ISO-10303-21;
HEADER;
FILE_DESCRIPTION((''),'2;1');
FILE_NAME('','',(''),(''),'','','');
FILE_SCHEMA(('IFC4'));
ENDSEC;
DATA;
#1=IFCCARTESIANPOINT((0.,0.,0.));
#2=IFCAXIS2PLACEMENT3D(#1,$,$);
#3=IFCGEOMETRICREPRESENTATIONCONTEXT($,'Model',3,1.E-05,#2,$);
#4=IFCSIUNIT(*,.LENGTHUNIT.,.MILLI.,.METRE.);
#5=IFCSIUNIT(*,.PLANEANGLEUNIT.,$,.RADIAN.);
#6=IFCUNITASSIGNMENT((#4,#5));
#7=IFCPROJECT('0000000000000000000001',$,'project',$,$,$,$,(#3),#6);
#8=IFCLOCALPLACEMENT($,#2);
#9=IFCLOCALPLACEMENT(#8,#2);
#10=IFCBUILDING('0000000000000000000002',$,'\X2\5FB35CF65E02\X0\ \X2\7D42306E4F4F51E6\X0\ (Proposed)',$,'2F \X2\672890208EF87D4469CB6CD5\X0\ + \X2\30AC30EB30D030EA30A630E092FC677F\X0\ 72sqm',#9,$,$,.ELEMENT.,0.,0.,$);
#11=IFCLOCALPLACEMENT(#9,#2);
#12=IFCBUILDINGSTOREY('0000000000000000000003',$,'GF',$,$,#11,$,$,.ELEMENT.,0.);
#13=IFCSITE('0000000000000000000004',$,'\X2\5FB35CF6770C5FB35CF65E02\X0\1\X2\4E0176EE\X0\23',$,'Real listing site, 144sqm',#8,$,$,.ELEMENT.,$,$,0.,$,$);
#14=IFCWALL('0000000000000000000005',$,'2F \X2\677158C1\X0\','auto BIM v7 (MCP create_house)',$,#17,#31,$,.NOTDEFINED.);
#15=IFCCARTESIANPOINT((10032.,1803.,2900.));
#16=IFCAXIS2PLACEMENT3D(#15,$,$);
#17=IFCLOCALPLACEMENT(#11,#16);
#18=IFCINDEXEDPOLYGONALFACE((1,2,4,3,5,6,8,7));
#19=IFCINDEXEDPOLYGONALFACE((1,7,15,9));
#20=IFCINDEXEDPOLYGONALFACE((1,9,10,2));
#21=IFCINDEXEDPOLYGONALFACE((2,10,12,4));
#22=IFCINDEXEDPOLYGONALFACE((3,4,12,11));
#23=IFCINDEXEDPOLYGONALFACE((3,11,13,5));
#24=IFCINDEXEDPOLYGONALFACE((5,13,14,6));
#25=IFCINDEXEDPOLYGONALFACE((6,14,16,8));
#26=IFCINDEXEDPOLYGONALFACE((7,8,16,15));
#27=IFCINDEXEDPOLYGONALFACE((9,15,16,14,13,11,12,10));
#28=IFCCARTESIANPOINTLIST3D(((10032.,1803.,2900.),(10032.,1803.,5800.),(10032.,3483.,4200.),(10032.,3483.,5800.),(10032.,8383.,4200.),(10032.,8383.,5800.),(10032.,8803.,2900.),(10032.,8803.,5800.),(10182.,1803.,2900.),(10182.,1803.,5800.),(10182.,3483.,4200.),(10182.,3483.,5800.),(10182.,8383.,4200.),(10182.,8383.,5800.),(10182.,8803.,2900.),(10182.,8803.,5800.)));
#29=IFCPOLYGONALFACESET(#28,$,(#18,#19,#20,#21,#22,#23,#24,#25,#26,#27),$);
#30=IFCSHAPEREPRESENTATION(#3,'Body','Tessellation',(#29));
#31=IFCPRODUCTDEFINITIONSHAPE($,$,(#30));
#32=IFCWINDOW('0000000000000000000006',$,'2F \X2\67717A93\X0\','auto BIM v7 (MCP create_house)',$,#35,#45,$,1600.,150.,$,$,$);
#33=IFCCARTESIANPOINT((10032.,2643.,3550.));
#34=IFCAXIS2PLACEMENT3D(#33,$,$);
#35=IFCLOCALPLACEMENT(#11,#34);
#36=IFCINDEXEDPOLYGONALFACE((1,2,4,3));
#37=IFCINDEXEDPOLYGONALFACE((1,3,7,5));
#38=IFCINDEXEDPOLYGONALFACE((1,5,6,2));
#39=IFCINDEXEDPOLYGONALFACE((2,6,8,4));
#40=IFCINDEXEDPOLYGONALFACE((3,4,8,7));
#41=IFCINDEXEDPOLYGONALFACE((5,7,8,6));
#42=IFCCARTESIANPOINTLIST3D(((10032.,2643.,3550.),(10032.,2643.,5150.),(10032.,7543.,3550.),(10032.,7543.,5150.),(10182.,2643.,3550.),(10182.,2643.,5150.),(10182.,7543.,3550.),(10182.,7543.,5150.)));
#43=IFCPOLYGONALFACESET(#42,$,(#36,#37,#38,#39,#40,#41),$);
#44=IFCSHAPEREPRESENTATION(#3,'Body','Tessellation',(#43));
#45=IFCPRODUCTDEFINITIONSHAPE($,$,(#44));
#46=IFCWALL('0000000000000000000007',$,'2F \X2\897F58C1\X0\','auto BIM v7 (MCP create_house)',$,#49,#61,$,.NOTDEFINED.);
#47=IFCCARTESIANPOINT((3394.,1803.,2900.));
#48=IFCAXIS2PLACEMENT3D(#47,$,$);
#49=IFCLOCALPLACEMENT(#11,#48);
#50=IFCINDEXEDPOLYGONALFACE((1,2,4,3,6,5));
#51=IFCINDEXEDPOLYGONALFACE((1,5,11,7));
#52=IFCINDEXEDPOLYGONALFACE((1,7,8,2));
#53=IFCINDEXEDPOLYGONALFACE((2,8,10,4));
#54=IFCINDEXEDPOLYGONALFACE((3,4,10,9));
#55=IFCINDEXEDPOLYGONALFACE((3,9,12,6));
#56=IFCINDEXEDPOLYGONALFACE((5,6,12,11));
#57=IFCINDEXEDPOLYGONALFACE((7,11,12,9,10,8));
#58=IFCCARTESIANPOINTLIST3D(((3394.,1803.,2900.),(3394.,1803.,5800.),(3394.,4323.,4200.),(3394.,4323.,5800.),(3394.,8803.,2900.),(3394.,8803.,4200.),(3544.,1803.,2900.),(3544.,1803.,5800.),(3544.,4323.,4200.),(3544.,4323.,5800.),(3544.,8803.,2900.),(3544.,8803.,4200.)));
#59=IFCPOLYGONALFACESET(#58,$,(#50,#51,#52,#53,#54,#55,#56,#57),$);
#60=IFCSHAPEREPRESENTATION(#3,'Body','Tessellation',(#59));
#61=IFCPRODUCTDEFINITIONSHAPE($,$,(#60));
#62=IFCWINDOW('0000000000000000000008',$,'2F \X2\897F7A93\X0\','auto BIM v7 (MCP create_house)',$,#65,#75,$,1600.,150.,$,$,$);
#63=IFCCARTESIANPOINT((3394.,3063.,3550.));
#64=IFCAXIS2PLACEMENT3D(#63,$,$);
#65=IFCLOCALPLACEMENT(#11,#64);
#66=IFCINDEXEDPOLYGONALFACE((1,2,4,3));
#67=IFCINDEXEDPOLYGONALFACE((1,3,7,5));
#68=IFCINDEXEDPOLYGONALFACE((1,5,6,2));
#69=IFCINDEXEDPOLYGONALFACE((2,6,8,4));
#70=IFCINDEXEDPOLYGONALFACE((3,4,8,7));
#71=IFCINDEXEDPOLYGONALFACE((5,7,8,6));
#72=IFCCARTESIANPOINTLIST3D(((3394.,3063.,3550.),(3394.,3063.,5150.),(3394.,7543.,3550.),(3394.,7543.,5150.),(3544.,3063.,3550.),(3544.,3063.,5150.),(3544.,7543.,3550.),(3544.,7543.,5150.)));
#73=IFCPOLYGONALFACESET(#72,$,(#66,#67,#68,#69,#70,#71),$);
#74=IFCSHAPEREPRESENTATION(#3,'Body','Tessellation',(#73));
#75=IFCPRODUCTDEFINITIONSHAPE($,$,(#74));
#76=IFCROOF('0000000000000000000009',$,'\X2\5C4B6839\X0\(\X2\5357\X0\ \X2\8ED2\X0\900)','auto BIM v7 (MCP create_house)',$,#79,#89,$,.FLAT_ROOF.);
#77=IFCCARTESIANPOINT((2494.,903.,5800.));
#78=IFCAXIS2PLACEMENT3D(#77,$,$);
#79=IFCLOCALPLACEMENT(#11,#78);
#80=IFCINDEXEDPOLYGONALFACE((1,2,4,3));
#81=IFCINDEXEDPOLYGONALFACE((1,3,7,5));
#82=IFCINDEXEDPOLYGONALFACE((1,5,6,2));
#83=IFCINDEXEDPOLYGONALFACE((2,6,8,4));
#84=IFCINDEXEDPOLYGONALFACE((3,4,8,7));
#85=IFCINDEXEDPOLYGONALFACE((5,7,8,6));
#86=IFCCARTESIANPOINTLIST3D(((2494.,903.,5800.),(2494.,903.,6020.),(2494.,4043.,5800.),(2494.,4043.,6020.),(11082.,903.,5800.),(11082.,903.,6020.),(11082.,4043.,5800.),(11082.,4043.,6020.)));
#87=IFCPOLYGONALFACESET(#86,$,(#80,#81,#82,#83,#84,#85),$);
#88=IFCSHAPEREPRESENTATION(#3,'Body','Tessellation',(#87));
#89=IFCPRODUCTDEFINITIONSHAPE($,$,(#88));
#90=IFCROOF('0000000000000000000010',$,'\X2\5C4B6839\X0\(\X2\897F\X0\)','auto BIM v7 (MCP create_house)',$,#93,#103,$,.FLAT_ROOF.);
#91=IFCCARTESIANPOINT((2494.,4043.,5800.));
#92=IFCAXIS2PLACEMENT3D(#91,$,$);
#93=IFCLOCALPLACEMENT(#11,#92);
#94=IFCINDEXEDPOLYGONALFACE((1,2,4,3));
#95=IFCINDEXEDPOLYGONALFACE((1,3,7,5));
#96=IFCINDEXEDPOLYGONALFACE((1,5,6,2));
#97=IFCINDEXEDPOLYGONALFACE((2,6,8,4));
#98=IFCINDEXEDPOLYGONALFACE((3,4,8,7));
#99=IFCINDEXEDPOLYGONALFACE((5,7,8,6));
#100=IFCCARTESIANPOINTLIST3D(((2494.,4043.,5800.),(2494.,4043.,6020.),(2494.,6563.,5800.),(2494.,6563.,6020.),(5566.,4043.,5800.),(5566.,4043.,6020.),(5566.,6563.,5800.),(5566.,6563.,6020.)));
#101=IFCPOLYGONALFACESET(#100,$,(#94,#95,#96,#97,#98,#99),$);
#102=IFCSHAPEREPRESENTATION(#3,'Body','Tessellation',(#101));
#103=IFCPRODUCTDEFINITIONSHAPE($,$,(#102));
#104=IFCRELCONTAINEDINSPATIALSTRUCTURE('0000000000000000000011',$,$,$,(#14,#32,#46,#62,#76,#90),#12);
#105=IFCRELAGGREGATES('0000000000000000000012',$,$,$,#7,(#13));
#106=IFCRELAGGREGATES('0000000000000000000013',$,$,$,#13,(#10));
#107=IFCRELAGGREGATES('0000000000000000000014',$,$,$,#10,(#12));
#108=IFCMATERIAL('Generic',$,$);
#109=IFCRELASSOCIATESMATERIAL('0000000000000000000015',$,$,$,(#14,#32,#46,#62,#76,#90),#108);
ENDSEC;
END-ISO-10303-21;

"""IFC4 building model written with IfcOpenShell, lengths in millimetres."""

from ifc_helpers import new_model, si_unit, frame, frame_2d, origin, place, context, project, spatial, rectangle, extrude, material, element, fill, save


model = new_model("IFC4")

# Units and contexts
model_context = context("Model", 3, precision=1e-05, world=origin())
ifc_project = project(units=[si_unit("LENGTHUNIT", "METRE", prefix="MILLI"), si_unit("PLANEANGLEUNIT", "RADIAN")], contexts=[model_context])

# Site, building, storey
site_placement = place(None, origin())
site = spatial("IfcSite", under=ifc_project, at=site_placement, Name="徳島県徳島市1丁目23", ObjectType="Real listing site, 144sqm", CompositionType="ELEMENT", RefElevation=0.0)
building_placement = place(site_placement, origin())
building = spatial("IfcBuilding", under=site, at=building_placement, Name="徳島市 終の住処 (Proposed)", ObjectType="2F 木造軸組構法 + ガルバリウム鋼板 72sqm", CompositionType="ELEMENT", ElevationOfRefHeight=0.0, ElevationOfTerrain=0.0)
storey_placement = place(building_placement, origin())
storey = spatial("IfcBuildingStorey", under=building, at=storey_placement, Name="GF", CompositionType="ELEMENT", Elevation=0.0)

# Shared definitions
ifc_material = material(Name="Generic")

# Walls, openings, windows
wall_1_placement = place(storey_placement, frame((10032.0, 1803.0, 2900.0)))
wall_1 = element("IfcWall", 1, at=wall_1_placement, inside=storey, material=ifc_material, Name="2F 東壁", Description="auto BIM v7 (MCP create_house)", PredefinedType="NOTDEFINED", context=model_context, shape_type="SweptSolid", body=[
    extrude(rectangle(XDim=150.0, YDim=7000.0, at=frame_2d((75.0, 3500.0))), frame((10032.0, 1803.0, 2900.0)), (0.0, 0.0, 1.0), 2900.0),
])
opening_1_placement = place(storey_placement, frame((10032.0, 2643.0, 3550.0)))
opening_1 = element("IfcOpeningElement", 2, at=opening_1_placement, cuts=wall_1, PredefinedType="NOTDEFINED", context=model_context, shape_type="SweptSolid", body=[
    extrude(rectangle(XDim=150.0, YDim=4900.0, at=frame_2d((75.0, 2450.0))), frame((10032.0, 2643.0, 3550.0)), (0.0, 0.0, 1.0), 1600.0),
])
window_1_placement = place(storey_placement, frame((10032.0, 2643.0, 3550.0)))
window_1 = element("IfcWindow", 3, at=window_1_placement, inside=storey, material=ifc_material, Name="2F 東窓", Description="auto BIM v7 (MCP create_house)", OverallHeight=1600.0, OverallWidth=150.0, context=model_context, shape_type="SweptSolid", body=[
    extrude(rectangle(XDim=150.0, YDim=4900.0, at=frame_2d((75.0, 2450.0))), frame((10032.0, 2643.0, 3550.0)), (0.0, 0.0, 1.0), 1600.0),
])
fill(opening_1, window_1)
wall_2_placement = place(storey_placement, frame((3394.0, 1803.0, 2900.0)))
wall_2 = element("IfcWall", 4, at=wall_2_placement, inside=storey, material=ifc_material, Name="2F 西壁", Description="auto BIM v7 (MCP create_house)", PredefinedType="NOTDEFINED", context=model_context, shape_type="SweptSolid", body=[
    extrude(rectangle(XDim=150.0, YDim=7000.0, at=frame_2d((75.0, 3500.0))), frame((3394.0, 1803.0, 2900.0)), (0.0, 0.0, 1.0), 2900.0),
])
opening_2_placement = place(storey_placement, frame((3394.0, 3063.0, 3550.0)))
opening_2 = element("IfcOpeningElement", 5, at=opening_2_placement, cuts=wall_2, PredefinedType="NOTDEFINED", context=model_context, shape_type="SweptSolid", body=[
    extrude(rectangle(XDim=150.0, YDim=4480.0, at=frame_2d((75.0, 2240.0))), frame((3394.0, 3063.0, 3550.0)), (0.0, 0.0, 1.0), 1600.0),
])
window_2_placement = place(storey_placement, frame((3394.0, 3063.0, 3550.0)))
window_2 = element("IfcWindow", 6, at=window_2_placement, inside=storey, material=ifc_material, Name="2F 西窓", Description="auto BIM v7 (MCP create_house)", OverallHeight=1600.0, OverallWidth=150.0, context=model_context, shape_type="SweptSolid", body=[
    extrude(rectangle(XDim=150.0, YDim=4480.0, at=frame_2d((75.0, 2240.0))), frame((3394.0, 3063.0, 3550.0)), (0.0, 0.0, 1.0), 1600.0),
])
fill(opening_2, window_2)

# Roofs
roof_1_placement = place(storey_placement, frame((2494.0, 903.0, 5800.0)))
element("IfcRoof", 7, at=roof_1_placement, inside=storey, material=ifc_material, Name="屋根(南 軒900)", Description="auto BIM v7 (MCP create_house)", PredefinedType="FLAT_ROOF", context=model_context, shape_type="SweptSolid", body=[
    extrude(rectangle(XDim=8588.0, YDim=3140.0, at=frame_2d((4294.0, 1570.0))), frame((2494.0, 903.0, 5800.0)), (0.0, 0.0, 1.0), 220.0),
])
roof_2_placement = place(storey_placement, frame((2494.0, 4043.0, 5800.0)))
element("IfcRoof", 8, at=roof_2_placement, inside=storey, material=ifc_material, Name="屋根(西)", Description="auto BIM v7 (MCP create_house)", PredefinedType="FLAT_ROOF", context=model_context, shape_type="SweptSolid", body=[
    extrude(rectangle(XDim=3072.0, YDim=2520.0, at=frame_2d((1536.0, 1260.0))), frame((2494.0, 4043.0, 5800.0)), (0.0, 0.0, 1.0), 220.0),
])

save(model, "model.ifc")
